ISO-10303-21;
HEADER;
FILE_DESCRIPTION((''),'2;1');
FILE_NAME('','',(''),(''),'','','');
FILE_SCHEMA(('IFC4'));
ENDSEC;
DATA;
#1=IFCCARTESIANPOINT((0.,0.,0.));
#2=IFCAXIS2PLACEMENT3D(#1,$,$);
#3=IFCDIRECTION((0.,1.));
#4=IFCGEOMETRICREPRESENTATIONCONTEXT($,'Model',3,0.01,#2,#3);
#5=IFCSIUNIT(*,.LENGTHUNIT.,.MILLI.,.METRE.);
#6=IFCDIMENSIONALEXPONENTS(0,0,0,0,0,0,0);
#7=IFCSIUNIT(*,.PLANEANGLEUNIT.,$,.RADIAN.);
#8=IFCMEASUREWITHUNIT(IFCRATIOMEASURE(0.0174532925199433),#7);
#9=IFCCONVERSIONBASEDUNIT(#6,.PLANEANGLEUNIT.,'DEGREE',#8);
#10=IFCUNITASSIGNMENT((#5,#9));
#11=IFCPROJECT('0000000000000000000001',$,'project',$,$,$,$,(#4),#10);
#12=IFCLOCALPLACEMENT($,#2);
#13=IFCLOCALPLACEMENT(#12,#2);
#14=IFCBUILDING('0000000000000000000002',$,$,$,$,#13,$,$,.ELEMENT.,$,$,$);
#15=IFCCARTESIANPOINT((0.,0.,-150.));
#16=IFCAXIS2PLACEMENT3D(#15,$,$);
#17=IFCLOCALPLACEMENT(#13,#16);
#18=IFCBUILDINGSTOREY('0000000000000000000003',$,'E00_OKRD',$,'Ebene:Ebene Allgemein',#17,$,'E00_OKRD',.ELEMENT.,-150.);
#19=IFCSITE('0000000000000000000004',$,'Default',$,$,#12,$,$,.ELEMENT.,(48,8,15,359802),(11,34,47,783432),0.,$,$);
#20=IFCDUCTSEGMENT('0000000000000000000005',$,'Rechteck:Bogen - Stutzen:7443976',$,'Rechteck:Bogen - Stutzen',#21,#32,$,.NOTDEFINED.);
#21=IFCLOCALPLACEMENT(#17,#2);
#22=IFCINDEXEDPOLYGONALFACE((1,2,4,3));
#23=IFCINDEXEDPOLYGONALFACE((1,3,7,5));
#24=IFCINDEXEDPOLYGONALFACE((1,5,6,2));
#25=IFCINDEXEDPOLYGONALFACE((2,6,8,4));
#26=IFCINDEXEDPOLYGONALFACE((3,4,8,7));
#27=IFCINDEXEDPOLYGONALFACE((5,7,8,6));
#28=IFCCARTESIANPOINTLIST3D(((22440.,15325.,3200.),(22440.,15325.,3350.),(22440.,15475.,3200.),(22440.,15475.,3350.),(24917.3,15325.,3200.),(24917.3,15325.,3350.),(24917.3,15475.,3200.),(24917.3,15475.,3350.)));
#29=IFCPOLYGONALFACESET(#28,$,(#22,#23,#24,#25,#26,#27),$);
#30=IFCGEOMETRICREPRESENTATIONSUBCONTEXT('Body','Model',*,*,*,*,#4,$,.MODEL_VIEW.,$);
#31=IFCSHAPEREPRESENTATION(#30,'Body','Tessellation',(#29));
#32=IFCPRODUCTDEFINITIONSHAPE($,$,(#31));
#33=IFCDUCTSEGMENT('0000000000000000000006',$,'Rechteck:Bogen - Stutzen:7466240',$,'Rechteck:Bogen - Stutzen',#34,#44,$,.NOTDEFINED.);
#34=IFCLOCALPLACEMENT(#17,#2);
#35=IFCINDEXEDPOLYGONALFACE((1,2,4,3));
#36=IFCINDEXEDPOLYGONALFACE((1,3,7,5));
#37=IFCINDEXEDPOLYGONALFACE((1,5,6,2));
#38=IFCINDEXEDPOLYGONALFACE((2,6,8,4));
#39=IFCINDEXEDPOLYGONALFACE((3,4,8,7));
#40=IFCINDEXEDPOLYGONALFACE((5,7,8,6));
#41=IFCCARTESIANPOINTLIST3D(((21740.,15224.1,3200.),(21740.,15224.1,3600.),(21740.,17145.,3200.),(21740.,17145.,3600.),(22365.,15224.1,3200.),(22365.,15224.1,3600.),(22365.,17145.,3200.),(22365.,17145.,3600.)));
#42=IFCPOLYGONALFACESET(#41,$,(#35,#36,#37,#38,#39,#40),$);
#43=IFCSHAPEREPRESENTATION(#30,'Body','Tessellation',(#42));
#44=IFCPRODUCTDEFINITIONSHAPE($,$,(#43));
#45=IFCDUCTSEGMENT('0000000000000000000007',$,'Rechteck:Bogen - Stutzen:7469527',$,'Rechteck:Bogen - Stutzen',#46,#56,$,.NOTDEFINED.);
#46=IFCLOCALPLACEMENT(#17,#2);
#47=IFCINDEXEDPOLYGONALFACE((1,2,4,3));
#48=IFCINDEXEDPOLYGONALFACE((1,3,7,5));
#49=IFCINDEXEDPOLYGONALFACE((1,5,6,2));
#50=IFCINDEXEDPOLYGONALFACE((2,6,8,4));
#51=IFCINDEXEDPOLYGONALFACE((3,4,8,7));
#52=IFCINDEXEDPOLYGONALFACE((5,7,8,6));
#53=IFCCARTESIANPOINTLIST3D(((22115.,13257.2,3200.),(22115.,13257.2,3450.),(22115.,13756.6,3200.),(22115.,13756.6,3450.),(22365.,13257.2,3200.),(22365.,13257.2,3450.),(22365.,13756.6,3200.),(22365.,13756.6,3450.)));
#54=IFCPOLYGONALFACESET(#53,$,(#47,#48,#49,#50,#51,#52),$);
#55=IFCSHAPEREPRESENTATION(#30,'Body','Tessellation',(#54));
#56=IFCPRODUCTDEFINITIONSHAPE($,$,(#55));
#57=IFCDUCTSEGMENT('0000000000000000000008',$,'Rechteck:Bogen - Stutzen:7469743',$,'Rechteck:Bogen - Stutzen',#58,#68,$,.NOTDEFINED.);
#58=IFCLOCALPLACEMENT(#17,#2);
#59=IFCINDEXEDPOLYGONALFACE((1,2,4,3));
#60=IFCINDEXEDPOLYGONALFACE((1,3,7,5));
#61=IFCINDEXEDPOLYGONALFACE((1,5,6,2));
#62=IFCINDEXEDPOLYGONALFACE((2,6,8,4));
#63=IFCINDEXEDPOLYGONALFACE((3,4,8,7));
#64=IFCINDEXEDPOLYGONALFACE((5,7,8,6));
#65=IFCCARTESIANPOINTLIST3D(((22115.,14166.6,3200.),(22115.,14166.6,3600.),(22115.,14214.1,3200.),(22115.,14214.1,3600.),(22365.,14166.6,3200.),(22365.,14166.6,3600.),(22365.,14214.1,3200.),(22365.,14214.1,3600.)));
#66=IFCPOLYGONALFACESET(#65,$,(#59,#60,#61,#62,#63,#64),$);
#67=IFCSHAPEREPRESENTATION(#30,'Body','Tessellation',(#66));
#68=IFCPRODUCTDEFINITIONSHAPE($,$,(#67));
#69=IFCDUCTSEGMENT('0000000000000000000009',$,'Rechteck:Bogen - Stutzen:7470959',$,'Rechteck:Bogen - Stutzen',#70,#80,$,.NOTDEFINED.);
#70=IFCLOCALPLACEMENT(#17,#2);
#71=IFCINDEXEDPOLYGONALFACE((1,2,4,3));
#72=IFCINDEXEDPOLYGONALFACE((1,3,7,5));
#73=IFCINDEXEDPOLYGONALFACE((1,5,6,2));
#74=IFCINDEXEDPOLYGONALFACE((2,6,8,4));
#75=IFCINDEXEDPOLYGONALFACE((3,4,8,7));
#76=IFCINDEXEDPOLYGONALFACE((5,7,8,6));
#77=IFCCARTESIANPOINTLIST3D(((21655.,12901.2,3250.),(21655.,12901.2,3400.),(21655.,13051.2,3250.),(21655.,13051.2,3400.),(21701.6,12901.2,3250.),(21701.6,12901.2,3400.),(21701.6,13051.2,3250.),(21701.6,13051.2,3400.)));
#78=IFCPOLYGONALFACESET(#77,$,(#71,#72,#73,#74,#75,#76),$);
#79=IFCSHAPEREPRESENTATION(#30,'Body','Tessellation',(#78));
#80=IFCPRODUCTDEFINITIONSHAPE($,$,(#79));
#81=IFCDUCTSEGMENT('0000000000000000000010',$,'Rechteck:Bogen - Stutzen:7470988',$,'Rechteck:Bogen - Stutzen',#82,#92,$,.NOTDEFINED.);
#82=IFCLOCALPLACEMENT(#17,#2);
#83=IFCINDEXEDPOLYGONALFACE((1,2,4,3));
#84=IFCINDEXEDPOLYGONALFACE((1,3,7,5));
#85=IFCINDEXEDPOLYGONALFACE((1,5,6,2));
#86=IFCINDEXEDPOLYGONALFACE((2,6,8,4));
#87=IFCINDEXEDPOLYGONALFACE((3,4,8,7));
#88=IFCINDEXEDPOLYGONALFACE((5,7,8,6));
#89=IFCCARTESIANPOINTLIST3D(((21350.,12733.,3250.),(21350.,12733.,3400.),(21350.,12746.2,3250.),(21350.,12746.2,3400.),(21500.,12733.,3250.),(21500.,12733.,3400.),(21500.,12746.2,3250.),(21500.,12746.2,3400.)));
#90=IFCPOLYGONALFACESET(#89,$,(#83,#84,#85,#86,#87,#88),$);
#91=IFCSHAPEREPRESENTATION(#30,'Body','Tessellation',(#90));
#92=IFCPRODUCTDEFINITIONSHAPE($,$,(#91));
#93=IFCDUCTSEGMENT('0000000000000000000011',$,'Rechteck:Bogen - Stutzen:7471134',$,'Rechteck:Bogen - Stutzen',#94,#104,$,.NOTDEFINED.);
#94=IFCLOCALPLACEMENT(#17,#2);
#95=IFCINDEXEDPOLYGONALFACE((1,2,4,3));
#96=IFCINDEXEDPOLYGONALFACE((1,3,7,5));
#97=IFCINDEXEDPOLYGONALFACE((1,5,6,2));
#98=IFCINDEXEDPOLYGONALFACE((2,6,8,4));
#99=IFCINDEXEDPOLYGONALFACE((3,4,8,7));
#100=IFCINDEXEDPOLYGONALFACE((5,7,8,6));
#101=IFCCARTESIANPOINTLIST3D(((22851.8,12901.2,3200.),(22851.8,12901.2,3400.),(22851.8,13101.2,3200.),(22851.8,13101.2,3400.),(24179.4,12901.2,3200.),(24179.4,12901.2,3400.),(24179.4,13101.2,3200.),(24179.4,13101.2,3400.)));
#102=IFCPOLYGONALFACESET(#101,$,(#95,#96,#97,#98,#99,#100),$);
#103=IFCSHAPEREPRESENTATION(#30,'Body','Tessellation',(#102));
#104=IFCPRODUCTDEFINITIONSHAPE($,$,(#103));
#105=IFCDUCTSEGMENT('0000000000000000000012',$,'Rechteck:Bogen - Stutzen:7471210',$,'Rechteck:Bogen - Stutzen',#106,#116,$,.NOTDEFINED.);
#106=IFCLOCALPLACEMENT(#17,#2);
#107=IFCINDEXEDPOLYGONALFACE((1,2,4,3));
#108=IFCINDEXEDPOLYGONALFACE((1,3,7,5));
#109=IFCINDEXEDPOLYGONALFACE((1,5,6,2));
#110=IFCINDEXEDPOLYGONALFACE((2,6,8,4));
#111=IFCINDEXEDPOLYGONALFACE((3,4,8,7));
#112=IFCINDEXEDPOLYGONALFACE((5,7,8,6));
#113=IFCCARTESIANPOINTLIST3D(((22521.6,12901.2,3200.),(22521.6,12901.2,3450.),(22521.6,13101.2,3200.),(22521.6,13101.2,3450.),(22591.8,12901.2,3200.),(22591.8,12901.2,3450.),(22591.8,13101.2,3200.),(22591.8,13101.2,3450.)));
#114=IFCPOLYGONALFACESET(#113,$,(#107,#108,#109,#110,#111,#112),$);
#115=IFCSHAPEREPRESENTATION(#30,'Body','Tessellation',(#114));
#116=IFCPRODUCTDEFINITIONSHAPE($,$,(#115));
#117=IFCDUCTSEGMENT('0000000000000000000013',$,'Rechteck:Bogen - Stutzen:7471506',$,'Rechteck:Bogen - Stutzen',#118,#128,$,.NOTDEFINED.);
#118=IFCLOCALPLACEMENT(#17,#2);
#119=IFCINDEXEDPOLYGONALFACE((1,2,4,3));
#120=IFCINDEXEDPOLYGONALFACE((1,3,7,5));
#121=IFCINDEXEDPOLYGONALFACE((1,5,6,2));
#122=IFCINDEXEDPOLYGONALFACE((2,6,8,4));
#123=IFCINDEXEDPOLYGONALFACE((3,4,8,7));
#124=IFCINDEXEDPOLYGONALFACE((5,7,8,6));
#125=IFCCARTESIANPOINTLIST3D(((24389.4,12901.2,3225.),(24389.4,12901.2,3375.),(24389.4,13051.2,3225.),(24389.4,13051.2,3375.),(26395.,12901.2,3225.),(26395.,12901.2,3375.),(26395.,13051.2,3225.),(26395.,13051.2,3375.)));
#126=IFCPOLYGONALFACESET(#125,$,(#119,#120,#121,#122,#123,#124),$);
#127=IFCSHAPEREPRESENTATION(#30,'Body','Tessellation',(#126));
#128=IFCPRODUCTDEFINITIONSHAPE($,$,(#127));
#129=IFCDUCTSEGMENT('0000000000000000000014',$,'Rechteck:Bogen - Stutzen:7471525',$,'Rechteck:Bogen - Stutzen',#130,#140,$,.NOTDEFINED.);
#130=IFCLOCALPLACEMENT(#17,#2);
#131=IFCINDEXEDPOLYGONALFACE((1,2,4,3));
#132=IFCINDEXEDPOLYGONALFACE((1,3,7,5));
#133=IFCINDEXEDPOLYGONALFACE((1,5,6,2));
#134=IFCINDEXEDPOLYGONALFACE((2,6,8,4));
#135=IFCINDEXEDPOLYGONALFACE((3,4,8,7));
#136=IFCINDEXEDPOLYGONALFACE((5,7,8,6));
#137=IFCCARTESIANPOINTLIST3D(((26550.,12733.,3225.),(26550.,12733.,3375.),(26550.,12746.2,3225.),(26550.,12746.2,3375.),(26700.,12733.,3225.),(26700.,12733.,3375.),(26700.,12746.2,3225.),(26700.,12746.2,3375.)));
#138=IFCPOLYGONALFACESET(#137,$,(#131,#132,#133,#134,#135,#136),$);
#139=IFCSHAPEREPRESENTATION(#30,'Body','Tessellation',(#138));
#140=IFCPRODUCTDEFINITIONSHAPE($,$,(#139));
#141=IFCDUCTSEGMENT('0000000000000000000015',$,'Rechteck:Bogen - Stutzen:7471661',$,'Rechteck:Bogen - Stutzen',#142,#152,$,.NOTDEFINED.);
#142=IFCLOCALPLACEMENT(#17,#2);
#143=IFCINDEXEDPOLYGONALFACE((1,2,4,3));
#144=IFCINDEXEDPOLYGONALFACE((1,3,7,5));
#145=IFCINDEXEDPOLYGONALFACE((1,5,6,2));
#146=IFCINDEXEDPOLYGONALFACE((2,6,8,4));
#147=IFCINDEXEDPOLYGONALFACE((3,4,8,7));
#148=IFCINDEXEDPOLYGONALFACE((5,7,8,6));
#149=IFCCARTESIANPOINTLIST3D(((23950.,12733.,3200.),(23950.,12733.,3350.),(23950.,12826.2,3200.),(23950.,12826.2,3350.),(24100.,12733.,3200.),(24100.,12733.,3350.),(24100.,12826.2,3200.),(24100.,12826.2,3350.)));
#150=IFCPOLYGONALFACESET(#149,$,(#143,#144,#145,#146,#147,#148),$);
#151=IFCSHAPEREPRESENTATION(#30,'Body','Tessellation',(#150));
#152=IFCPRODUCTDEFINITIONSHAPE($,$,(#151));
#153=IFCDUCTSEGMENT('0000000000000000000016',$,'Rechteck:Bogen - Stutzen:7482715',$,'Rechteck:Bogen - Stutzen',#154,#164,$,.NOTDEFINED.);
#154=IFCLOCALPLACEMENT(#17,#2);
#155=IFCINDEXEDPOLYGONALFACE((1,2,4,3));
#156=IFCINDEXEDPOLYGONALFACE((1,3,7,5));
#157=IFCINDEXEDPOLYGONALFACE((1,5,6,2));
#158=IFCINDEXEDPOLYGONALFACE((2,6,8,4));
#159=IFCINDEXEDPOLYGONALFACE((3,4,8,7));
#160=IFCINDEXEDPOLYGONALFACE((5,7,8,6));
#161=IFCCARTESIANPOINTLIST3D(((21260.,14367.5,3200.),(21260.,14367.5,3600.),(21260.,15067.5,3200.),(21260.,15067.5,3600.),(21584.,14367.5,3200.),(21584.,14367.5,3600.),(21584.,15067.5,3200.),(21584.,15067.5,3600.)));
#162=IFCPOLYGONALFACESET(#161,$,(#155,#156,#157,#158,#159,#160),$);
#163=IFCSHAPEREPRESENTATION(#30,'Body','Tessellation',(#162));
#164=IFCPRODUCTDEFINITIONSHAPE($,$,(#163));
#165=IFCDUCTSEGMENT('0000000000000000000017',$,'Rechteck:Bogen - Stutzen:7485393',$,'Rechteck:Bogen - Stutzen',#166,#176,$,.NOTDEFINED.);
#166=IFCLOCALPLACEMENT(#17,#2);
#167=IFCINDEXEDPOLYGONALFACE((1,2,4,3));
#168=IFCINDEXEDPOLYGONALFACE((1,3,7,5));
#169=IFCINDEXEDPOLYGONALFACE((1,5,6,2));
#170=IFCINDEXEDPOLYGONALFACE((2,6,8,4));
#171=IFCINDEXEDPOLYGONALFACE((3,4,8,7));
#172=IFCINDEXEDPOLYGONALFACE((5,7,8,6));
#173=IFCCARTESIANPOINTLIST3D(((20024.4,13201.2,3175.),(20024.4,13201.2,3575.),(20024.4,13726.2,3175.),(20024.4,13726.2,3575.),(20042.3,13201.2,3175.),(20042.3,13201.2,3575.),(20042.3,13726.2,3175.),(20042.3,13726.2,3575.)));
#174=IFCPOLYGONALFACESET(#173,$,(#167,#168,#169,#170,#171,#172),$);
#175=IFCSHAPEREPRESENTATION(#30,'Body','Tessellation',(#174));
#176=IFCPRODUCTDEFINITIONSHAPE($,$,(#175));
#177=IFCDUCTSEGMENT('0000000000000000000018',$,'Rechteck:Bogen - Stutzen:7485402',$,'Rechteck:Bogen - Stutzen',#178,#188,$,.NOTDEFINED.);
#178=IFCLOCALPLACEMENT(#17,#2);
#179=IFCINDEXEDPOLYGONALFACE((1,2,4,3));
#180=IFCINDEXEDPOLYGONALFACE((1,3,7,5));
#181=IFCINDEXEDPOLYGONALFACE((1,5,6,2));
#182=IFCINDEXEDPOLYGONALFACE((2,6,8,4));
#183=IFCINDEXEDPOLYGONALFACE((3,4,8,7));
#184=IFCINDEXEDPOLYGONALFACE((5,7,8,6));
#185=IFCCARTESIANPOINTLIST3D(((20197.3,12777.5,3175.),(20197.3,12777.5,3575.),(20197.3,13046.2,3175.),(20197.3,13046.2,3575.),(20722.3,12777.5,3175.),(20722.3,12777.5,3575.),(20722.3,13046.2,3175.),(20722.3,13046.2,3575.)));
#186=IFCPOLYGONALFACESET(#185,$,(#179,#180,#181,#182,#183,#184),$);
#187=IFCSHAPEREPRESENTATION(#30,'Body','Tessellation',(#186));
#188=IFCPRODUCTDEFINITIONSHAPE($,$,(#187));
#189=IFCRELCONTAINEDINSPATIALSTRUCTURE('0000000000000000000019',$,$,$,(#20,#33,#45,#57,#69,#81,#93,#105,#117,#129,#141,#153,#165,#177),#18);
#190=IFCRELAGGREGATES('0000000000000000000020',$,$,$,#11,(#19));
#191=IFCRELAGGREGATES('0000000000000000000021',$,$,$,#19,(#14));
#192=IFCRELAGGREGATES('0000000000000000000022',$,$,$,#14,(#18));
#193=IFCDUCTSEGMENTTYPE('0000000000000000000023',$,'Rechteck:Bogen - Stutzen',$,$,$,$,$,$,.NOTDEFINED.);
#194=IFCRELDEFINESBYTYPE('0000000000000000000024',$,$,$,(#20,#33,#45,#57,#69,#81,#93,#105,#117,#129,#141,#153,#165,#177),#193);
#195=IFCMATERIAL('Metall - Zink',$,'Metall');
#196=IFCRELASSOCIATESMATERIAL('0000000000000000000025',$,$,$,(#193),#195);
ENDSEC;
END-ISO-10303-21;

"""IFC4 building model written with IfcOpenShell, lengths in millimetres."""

from ifc_helpers import new_model, entity, si_unit, converted_unit, direction, frame, frame_2d, origin, origin_2d_with_axis, place, context, subcontext, project, spatial, rectangle, extrude, material, type_object, element, save


model = new_model("IFC4")

# Units and contexts
model_context = context("Model", 3, precision=0.01, world=origin(), true_north=direction((0.0, 1.0)))
body_context = subcontext(model_context, "Body", "Model", "MODEL_VIEW")
ifc_project = project(units=[si_unit("LENGTHUNIT", "METRE", prefix="MILLI"), converted_unit("PLANEANGLEUNIT", "DEGREE", entity("IfcRatioMeasure", 0.0174532925199433), si_unit("PLANEANGLEUNIT", "RADIAN"), dimensions=[0, 0, 0, 0, 0, 0, 0])], contexts=[model_context])

# Site, building, storey
site_placement = place(None, origin())
site = spatial("IfcSite", under=ifc_project, at=site_placement, Name="Default", CompositionType="ELEMENT", RefLatitude=(48, 8, 15, 359802), RefLongitude=(11, 34, 47, 783432), RefElevation=0.0)
building_placement = place(site_placement, origin())
building = spatial("IfcBuilding", under=site, at=building_placement, CompositionType="ELEMENT")
storey_placement = place(building_placement, frame((0.0, 0.0, -150.0)))
storey = spatial("IfcBuildingStorey", under=building, at=storey_placement, Name="E00_OKRD", ObjectType="Ebene:Ebene Allgemein", LongName="E00_OKRD", CompositionType="ELEMENT", Elevation=-150.0)

# Duct segments
ifc_material = material(Name="Metall - Zink", Category="Metall")
duct_segment_type_1 = type_object("IfcDuctSegmentType", Name="Rechteck:Bogen - Stutzen", PredefinedType="NOTDEFINED", material=ifc_material)
duct_segment_1_placement = place(storey_placement, frame((22440.0, 15325.0, 3200.0)))
element("IfcDuctSegment", 1, at=duct_segment_1_placement, inside=storey, type_object=duct_segment_type_1, Name="Rechteck:Bogen - Stutzen:7443976", ObjectType="Rechteck:Bogen - Stutzen", PredefinedType="NOTDEFINED", context=body_context, shape_type="SweptSolid", body=[
    extrude(rectangle(XDim=2477.3, YDim=150.0, at=frame_2d((0.0, 0.0), x_axis=(1.0, 0.0))), frame((1238.6, 75.0, 0.0)), (0.0, 0.0, 1.0), 150.0),
])
duct_segment_2_placement = place(storey_placement, frame((21740.0, 15224.1, 3200.0)))
element("IfcDuctSegment", 2, at=duct_segment_2_placement, inside=storey, type_object=duct_segment_type_1, Name="Rechteck:Bogen - Stutzen:7466240", ObjectType="Rechteck:Bogen - Stutzen", PredefinedType="NOTDEFINED", context=body_context, shape_type="SweptSolid", body=[
    extrude(rectangle(XDim=1920.9, YDim=625.0, at=frame_2d((0.0, 0.0), x_axis=(1.0, 0.0))), frame((312.5, 960.4, 0.0), z_axis=(0.0, 0.0, 1.0), x_axis=(0.0, -1.0, 0.0)), (0.0, 0.0, 1.0), 400.0),
])
duct_segment_3_placement = place(storey_placement, frame((22115.0, 13257.2, 3200.0)))
element("IfcDuctSegment", 3, at=duct_segment_3_placement, inside=storey, type_object=duct_segment_type_1, Name="Rechteck:Bogen - Stutzen:7469527", ObjectType="Rechteck:Bogen - Stutzen", PredefinedType="NOTDEFINED", context=body_context, shape_type="SweptSolid", body=[
    extrude(rectangle(XDim=499.4, YDim=250.0, at=frame_2d((0.0, 0.0), x_axis=(1.0, 0.0))), frame((125.0, 249.7, 0.0), z_axis=(0.0, 0.0, 1.0), x_axis=(0.0, -1.0, 0.0)), (0.0, 0.0, 1.0), 250.0),
])
duct_segment_4_placement = place(storey_placement, frame((22115.0, 14166.6, 3200.0)))
element("IfcDuctSegment", 4, at=duct_segment_4_placement, inside=storey, type_object=duct_segment_type_1, Name="Rechteck:Bogen - Stutzen:7469743", ObjectType="Rechteck:Bogen - Stutzen", PredefinedType="NOTDEFINED", context=body_context, shape_type="SweptSolid", body=[
    extrude(rectangle(XDim=47.5, YDim=250.0, at=frame_2d((0.0, 0.0), x_axis=(1.0, 0.0))), frame((125.0, 23.8, 0.0), z_axis=(0.0, 0.0, 1.0), x_axis=(0.0, 1.0, 0.0)), (0.0, 0.0, 1.0), 400.0),
])
duct_segment_5_placement = place(storey_placement, frame((21655.0, 12901.2, 3250.0)))
element("IfcDuctSegment", 5, at=duct_segment_5_placement, inside=storey, type_object=duct_segment_type_1, Name="Rechteck:Bogen - Stutzen:7470959", ObjectType="Rechteck:Bogen - Stutzen", PredefinedType="NOTDEFINED", context=body_context, shape_type="SweptSolid", body=[
    extrude(rectangle(XDim=46.6, YDim=150.0, at=frame_2d((0.0, 0.0), x_axis=(1.0, 0.0))), frame((23.3, 75.0, 0.0), z_axis=(0.0, 0.0, 1.0), x_axis=(-1.0, 0.0, 0.0)), (0.0, 0.0, 1.0), 150.0),
])
duct_segment_6_placement = place(storey_placement, frame((21350.0, 12733.0, 3250.0)))
element("IfcDuctSegment", 6, at=duct_segment_6_placement, inside=storey, type_object=duct_segment_type_1, Name="Rechteck:Bogen - Stutzen:7470988", ObjectType="Rechteck:Bogen - Stutzen", PredefinedType="NOTDEFINED", context=body_context, shape_type="SweptSolid", body=[
    extrude(rectangle(XDim=13.2, YDim=150.0, at=frame_2d((0.0, 0.0), x_axis=(1.0, 0.0))), frame((75.0, 6.6, 0.0), z_axis=(0.0, 0.0, 1.0), x_axis=(0.0, 1.0, 0.0)), (0.0, 0.0, 1.0), 150.0),
])
duct_segment_7_placement = place(storey_placement, frame((22851.8, 12901.2, 3200.0)))
element("IfcDuctSegment", 7, at=duct_segment_7_placement, inside=storey, type_object=duct_segment_type_1, Name="Rechteck:Bogen - Stutzen:7471134", ObjectType="Rechteck:Bogen - Stutzen", PredefinedType="NOTDEFINED", context=body_context, shape_type="SweptSolid", body=[
    extrude(rectangle(XDim=1327.6, YDim=200.0, at=frame_2d((0.0, 0.0), x_axis=(1.0, 0.0))), frame((663.8, 100.0, 0.0)), (0.0, 0.0, 1.0), 200.0),
])
duct_segment_8_placement = place(storey_placement, frame((22521.6, 12901.2, 3200.0)))
element("IfcDuctSegment", 8, at=duct_segment_8_placement, inside=storey, type_object=duct_segment_type_1, Name="Rechteck:Bogen - Stutzen:7471210", ObjectType="Rechteck:Bogen - Stutzen", PredefinedType="NOTDEFINED", context=body_context, shape_type="SweptSolid", body=[
    extrude(rectangle(XDim=70.2, YDim=200.0, at=frame_2d((0.0, 0.0), x_axis=(1.0, 0.0))), frame((35.1, 100.0, 0.0)), (0.0, 0.0, 1.0), 250.0),
])
duct_segment_9_placement = place(storey_placement, frame((24389.4, 12901.2, 3225.0)))
element("IfcDuctSegment", 9, at=duct_segment_9_placement, inside=storey, type_object=duct_segment_type_1, Name="Rechteck:Bogen - Stutzen:7471506", ObjectType="Rechteck:Bogen - Stutzen", PredefinedType="NOTDEFINED", context=body_context, shape_type="SweptSolid", body=[
    extrude(rectangle(XDim=2005.6, YDim=150.0, at=origin_2d_with_axis()), frame((1002.8, 75.0, 0.0)), (0.0, 0.0, 1.0), 150.0),
])
duct_segment_10_placement = place(storey_placement, frame((26550.0, 12733.0, 3225.0)))
element("IfcDuctSegment", 10, at=duct_segment_10_placement, inside=storey, type_object=duct_segment_type_1, Name="Rechteck:Bogen - Stutzen:7471525", ObjectType="Rechteck:Bogen - Stutzen", PredefinedType="NOTDEFINED", context=body_context, shape_type="SweptSolid", body=[
    extrude(rectangle(XDim=13.2, YDim=150.0, at=frame_2d((0.0, 0.0), x_axis=(1.0, 0.0))), frame((75.0, 6.6, 0.0), z_axis=(0.0, 0.0, 1.0), x_axis=(0.0, -1.0, 0.0)), (0.0, 0.0, 1.0), 150.0),
])
duct_segment_11_placement = place(storey_placement, frame((23950.0, 12733.0, 3200.0)))
element("IfcDuctSegment", 11, at=duct_segment_11_placement, inside=storey, type_object=duct_segment_type_1, Name="Rechteck:Bogen - Stutzen:7471661", ObjectType="Rechteck:Bogen - Stutzen", PredefinedType="NOTDEFINED", context=body_context, shape_type="SweptSolid", body=[
    extrude(rectangle(XDim=93.2, YDim=150.0, at=origin_2d_with_axis()), frame((75.0, 46.6, 0.0), z_axis=(0.0, 0.0, 1.0), x_axis=(0.0, -1.0, 0.0)), (0.0, 0.0, 1.0), 150.0),
])
duct_segment_12_placement = place(storey_placement, frame((21260.0, 14367.5, 3200.0)))
element("IfcDuctSegment", 12, at=duct_segment_12_placement, inside=storey, type_object=duct_segment_type_1, Name="Rechteck:Bogen - Stutzen:7482715", ObjectType="Rechteck:Bogen - Stutzen", PredefinedType="NOTDEFINED", context=body_context, shape_type="SweptSolid", body=[
    extrude(rectangle(XDim=324.0, YDim=700.0, at=frame_2d((0.0, 0.0), x_axis=(1.0, 0.0))), frame((162.0, 350.0, 0.0)), (0.0, 0.0, 1.0), 400.0),
])
duct_segment_13_placement = place(storey_placement, frame((20024.4, 13201.2, 3175.0)))
element("IfcDuctSegment", 13, at=duct_segment_13_placement, inside=storey, type_object=duct_segment_type_1, Name="Rechteck:Bogen - Stutzen:7485393", ObjectType="Rechteck:Bogen - Stutzen", PredefinedType="NOTDEFINED", context=body_context, shape_type="SweptSolid", body=[
    extrude(rectangle(XDim=17.9, YDim=525.0, at=origin_2d_with_axis()), frame((8.9, 262.5, 0.0)), (0.0, 0.0, 1.0), 400.0),
])
duct_segment_14_placement = place(storey_placement, frame((20197.3, 12777.5, 3175.0)))
element("IfcDuctSegment", 14, at=duct_segment_14_placement, inside=storey, type_object=duct_segment_type_1, Name="Rechteck:Bogen - Stutzen:7485402", ObjectType="Rechteck:Bogen - Stutzen", PredefinedType="NOTDEFINED", context=body_context, shape_type="SweptSolid", body=[
    extrude(rectangle(XDim=268.7, YDim=525.0, at=frame_2d((0.0, 0.0), x_axis=(1.0, 0.0))), frame((262.5, 134.4, 0.0), z_axis=(0.0, 0.0, 1.0), x_axis=(0.0, 1.0, 0.0)), (0.0, 0.0, 1.0), 400.0),
])

save(model, "model.ifc")
